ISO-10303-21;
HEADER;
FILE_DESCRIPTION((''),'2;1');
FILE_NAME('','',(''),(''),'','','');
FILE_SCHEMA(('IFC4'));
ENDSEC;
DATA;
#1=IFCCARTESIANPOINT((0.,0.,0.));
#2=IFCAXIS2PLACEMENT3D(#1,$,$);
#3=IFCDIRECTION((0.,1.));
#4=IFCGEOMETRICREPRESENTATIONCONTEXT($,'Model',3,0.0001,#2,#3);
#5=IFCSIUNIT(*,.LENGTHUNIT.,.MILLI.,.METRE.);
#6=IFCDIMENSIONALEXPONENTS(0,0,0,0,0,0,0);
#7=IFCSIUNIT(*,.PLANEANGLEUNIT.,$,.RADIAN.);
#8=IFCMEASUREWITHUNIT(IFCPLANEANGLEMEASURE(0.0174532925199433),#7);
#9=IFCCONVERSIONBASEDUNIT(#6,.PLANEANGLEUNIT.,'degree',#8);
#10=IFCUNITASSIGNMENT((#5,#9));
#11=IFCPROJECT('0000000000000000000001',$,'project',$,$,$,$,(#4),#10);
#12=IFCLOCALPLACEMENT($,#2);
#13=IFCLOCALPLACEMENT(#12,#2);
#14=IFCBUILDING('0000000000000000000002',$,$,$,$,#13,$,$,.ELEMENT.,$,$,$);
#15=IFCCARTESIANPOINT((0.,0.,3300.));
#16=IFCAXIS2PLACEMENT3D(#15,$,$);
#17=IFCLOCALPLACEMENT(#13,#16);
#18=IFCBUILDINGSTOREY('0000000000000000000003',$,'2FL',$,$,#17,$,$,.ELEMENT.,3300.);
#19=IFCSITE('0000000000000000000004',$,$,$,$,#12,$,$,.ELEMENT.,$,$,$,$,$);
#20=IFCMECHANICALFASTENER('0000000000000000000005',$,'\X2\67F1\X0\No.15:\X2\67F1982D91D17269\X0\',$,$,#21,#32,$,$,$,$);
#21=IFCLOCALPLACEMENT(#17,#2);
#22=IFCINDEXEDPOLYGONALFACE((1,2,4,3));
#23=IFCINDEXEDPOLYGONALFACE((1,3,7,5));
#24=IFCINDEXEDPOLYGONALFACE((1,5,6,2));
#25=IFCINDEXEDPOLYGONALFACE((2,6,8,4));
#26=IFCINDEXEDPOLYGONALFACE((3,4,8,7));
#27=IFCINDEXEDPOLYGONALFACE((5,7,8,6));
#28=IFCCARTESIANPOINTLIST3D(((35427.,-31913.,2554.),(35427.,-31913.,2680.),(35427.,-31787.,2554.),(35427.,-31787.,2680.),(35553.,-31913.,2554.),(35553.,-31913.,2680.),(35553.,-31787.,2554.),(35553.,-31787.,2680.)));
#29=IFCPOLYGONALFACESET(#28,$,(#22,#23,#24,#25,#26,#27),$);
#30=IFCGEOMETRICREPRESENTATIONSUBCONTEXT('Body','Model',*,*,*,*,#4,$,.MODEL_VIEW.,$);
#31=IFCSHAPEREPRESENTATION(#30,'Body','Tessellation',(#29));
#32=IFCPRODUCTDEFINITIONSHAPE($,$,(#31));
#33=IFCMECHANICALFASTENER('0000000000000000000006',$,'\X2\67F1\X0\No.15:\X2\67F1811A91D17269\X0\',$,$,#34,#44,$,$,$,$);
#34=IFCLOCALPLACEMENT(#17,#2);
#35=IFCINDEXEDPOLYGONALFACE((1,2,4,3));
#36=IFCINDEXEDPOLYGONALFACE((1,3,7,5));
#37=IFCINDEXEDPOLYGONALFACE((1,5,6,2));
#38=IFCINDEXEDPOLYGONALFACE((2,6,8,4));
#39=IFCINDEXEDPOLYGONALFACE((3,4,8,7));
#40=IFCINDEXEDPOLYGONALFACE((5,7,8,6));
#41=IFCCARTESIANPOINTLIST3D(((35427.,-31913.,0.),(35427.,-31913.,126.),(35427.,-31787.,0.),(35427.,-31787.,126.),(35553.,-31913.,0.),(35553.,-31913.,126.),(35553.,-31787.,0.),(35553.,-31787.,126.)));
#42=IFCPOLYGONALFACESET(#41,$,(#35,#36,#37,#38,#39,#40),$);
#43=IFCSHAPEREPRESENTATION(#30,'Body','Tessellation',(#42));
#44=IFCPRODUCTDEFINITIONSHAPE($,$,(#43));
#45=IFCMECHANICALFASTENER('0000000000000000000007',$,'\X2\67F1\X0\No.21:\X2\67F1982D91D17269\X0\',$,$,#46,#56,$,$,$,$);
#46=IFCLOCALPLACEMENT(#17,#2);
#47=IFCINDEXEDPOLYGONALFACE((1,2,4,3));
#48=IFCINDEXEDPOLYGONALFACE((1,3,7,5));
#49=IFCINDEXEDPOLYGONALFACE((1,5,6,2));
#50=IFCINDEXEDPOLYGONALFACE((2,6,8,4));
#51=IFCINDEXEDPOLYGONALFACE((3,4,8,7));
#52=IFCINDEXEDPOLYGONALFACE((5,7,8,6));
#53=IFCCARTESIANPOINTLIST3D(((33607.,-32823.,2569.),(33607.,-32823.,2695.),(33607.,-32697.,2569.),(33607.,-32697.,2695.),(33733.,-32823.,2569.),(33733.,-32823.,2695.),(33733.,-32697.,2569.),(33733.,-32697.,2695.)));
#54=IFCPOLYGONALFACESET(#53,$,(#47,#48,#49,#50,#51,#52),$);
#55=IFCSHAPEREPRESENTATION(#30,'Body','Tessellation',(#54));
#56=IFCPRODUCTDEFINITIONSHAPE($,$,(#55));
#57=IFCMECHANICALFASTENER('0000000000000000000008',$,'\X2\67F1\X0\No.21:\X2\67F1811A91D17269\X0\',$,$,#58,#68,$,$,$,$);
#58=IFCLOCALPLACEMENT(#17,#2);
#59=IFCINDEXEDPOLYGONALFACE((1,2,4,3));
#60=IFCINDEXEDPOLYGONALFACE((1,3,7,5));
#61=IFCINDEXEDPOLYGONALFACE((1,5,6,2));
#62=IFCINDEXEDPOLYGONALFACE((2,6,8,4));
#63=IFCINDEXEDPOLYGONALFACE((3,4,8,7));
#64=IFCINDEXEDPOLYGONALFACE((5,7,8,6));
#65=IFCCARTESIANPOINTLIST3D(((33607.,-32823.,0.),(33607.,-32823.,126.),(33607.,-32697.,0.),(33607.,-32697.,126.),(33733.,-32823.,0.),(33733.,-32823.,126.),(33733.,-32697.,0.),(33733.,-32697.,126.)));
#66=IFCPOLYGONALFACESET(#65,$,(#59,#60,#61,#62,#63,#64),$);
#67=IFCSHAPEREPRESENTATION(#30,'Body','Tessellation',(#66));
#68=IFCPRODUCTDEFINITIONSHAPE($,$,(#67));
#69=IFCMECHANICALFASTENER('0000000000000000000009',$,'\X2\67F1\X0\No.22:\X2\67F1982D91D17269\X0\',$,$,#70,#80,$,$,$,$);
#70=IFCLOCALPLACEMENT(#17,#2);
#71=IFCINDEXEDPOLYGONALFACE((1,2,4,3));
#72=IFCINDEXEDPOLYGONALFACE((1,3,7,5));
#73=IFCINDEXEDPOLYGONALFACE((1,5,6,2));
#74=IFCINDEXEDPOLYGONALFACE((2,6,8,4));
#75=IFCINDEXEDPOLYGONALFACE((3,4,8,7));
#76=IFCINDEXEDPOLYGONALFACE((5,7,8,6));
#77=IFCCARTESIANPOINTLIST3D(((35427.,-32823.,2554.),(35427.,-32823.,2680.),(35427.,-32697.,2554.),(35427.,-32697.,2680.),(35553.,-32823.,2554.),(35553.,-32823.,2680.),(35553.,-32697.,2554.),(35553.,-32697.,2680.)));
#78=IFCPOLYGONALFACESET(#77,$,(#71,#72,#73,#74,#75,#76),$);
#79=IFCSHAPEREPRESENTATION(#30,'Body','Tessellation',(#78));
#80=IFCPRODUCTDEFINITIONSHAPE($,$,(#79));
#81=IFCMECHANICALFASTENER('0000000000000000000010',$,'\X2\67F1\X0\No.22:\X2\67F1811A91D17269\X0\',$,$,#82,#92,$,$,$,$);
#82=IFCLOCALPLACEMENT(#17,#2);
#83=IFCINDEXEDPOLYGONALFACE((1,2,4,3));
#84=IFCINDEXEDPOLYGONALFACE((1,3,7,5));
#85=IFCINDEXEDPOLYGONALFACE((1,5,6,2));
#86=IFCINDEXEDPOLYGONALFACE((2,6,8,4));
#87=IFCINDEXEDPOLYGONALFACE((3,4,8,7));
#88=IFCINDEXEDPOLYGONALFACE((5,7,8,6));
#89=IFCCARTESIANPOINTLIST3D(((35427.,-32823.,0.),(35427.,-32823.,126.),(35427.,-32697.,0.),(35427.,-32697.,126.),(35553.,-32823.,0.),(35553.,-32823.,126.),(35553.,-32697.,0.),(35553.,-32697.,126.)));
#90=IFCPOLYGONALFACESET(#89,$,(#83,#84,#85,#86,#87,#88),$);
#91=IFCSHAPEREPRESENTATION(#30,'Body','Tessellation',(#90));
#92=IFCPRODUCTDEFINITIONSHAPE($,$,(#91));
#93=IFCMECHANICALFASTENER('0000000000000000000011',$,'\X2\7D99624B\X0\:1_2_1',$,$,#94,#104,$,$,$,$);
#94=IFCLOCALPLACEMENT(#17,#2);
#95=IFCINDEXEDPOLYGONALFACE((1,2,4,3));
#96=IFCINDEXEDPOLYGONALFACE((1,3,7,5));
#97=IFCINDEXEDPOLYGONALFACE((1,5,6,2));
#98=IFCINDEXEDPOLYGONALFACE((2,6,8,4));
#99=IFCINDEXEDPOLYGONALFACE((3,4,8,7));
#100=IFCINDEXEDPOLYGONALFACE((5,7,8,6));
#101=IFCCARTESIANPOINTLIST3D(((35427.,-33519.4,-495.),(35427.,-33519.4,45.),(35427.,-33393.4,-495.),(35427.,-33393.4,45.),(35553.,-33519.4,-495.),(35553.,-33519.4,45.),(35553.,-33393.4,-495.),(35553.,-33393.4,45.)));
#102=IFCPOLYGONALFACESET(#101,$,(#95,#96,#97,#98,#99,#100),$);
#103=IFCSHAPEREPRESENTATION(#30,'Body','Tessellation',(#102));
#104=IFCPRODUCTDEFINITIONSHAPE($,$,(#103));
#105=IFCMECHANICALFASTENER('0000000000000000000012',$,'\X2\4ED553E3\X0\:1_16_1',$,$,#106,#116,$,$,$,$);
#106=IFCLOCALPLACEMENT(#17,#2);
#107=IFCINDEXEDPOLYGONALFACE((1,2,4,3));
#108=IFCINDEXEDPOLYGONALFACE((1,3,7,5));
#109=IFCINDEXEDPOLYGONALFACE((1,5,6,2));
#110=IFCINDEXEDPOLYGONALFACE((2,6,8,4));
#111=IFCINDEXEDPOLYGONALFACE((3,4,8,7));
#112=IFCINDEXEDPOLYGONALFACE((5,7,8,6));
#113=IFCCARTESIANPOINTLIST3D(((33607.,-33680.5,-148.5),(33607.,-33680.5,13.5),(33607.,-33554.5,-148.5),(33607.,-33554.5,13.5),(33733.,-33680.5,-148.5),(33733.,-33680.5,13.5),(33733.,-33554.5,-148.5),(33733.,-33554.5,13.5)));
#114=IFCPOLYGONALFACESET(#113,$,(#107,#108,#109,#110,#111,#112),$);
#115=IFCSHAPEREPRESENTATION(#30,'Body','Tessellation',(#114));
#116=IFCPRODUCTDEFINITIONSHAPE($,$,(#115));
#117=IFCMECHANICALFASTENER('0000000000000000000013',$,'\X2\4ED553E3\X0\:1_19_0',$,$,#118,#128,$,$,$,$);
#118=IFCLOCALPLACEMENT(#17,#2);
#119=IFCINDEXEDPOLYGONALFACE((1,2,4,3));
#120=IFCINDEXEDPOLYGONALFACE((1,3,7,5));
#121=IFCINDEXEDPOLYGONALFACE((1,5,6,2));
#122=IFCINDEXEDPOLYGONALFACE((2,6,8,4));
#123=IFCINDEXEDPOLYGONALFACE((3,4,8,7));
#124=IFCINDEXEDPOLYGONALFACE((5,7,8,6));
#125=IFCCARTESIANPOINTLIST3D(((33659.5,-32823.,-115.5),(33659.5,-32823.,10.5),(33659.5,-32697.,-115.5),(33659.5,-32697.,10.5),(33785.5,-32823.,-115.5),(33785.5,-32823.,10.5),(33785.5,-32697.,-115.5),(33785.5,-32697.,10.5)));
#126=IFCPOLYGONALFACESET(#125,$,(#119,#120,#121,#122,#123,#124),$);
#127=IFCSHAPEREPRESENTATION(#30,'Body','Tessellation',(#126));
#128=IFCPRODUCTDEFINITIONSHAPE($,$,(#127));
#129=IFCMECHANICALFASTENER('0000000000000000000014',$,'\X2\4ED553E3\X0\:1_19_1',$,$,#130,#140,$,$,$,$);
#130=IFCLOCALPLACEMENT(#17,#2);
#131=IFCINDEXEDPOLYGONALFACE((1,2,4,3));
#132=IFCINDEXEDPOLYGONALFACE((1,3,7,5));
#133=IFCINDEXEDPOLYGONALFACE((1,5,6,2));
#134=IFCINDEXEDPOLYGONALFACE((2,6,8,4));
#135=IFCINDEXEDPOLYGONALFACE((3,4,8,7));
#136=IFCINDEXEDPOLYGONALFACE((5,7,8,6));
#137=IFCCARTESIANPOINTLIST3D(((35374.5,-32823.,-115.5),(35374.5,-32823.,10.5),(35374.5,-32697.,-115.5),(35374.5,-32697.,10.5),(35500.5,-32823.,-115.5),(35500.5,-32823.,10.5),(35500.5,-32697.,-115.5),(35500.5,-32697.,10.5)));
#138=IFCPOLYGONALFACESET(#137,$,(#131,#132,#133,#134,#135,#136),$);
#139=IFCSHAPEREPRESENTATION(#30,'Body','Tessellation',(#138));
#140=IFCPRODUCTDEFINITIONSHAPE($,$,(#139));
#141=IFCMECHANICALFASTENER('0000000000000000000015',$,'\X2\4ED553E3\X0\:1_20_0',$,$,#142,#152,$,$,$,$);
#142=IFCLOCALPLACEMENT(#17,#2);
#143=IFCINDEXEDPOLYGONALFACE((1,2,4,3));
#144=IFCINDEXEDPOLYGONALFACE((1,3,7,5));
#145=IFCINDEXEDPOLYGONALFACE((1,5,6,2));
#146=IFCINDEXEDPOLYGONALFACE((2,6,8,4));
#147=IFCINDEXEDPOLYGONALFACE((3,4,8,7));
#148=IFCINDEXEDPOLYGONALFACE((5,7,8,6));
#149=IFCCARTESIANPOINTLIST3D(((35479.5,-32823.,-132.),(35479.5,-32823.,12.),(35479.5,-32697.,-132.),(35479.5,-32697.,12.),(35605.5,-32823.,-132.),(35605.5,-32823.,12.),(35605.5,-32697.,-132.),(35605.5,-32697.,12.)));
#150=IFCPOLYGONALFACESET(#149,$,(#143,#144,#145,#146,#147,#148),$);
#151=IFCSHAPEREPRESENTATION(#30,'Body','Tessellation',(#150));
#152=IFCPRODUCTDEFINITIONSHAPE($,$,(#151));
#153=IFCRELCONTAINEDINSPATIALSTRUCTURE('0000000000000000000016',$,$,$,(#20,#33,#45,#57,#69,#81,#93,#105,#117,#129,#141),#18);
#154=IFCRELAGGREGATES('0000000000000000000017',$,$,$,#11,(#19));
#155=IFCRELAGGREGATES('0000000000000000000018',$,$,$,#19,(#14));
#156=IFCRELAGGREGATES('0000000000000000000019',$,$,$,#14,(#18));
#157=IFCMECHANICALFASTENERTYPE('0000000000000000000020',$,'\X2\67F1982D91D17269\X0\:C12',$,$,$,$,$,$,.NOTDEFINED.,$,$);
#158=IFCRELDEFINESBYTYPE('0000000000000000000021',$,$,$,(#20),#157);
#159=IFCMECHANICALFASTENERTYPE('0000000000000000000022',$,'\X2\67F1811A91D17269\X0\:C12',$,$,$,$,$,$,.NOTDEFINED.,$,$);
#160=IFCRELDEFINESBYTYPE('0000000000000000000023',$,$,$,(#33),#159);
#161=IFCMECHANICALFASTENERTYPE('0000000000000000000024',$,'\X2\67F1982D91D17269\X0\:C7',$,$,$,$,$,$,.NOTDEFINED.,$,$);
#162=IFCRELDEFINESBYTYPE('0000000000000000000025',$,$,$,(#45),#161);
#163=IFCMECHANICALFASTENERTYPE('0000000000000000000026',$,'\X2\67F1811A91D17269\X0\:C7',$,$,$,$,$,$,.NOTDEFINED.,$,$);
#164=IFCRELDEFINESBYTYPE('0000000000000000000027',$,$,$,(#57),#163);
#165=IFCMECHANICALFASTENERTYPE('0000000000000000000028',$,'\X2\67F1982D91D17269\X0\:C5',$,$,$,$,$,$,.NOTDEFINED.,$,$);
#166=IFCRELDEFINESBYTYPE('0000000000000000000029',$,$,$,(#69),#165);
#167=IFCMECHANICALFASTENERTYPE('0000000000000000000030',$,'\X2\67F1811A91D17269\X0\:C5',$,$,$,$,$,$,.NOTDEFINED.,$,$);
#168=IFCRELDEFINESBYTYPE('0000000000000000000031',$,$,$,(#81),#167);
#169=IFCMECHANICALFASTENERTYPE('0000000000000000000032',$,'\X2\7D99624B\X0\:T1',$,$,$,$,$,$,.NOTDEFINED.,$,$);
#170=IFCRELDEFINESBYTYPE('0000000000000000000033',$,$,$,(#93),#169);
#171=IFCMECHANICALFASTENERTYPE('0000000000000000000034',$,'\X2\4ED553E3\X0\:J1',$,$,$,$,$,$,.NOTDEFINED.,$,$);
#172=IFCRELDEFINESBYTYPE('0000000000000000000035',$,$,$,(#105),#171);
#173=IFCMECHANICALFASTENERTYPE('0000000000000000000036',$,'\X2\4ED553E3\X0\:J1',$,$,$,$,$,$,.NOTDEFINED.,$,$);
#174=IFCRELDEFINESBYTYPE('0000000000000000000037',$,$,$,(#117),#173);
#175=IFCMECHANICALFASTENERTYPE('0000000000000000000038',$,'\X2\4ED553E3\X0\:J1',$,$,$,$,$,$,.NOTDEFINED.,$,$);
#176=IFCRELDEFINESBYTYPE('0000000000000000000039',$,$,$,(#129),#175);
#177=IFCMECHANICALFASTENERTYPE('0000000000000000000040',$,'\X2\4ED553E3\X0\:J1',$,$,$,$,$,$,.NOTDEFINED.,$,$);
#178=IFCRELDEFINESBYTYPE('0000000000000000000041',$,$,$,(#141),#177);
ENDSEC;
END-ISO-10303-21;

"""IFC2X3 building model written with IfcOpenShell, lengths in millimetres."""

from ifc_helpers import new_model, entity, si_unit, converted_unit, direction, frame, origin, origin_with_axes, origin_2d, place, context, subcontext, project, spatial, rectangle, extrude, type_object, element, save


model = new_model("IFC2X3")

# Units and contexts
model_context = context("Model", 3, precision=0.0001, world=origin(), true_north=direction((0.0, 1.0)))
body_context = subcontext(model_context, "Body", "Model", "MODEL_VIEW")
ifc_project = project(units=[si_unit("LENGTHUNIT", "METRE", prefix="MILLI"), converted_unit("PLANEANGLEUNIT", "degree", entity("IfcPlaneAngleMeasure", 0.0174532925199433), si_unit("PLANEANGLEUNIT", "RADIAN"), dimensions=[0, 0, 0, 0, 0, 0, 0])], contexts=[model_context])

# Site, building, storey
site_placement = place(None, origin())
site = spatial("IfcSite", under=ifc_project, at=site_placement, CompositionType="ELEMENT")
building_placement = place(site_placement, origin())
building = spatial("IfcBuilding", under=site, at=building_placement, CompositionType="ELEMENT")
storey_placement = place(building_placement, frame((0.0, 0.0, 3300.0)))
storey = spatial("IfcBuildingStorey", under=building, at=storey_placement, Name="2FL", CompositionType="ELEMENT", Elevation=3300.0)

# Mechanical fasteners
mechanical_fastener_type_1 = type_object("IfcMechanicalFastenerType", Name="柱頭金物:C12")
mechanical_fastener_1_placement = place(storey_placement, frame((35490.0, -31850.0, 2554.0)))
element("IfcMechanicalFastener", 1, at=mechanical_fastener_1_placement, inside=storey, type_object=mechanical_fastener_type_1, Name="柱No.15:柱頭金物", context=body_context, shape_type="SweptSolid", body=[
    extrude(rectangle(XDim=126.0, YDim=126.0, at=origin_2d()), origin_with_axes(), (0.0, 0.0, 1.0), 126.0),
])
mechanical_fastener_type_2 = type_object("IfcMechanicalFastenerType", Name="柱脚金物:C12")
mechanical_fastener_2_placement = place(storey_placement, frame((35490.0, -31850.0, 0.0)))
element("IfcMechanicalFastener", 2, at=mechanical_fastener_2_placement, inside=storey, type_object=mechanical_fastener_type_2, Name="柱No.15:柱脚金物", context=body_context, shape_type="SweptSolid", body=[
    extrude(rectangle(XDim=126.0, YDim=126.0, at=origin_2d()), origin_with_axes(), (0.0, 0.0, 1.0), 126.0),
])
mechanical_fastener_type_3 = type_object("IfcMechanicalFastenerType", Name="柱頭金物:C7")
mechanical_fastener_3_placement = place(storey_placement, frame((33670.0, -32760.0, 2569.0)))
element("IfcMechanicalFastener", 3, at=mechanical_fastener_3_placement, inside=storey, type_object=mechanical_fastener_type_3, Name="柱No.21:柱頭金物", context=body_context, shape_type="SweptSolid", body=[
    extrude(rectangle(XDim=126.0, YDim=126.0, at=origin_2d()), origin_with_axes(), (0.0, 0.0, 1.0), 126.0),
])
mechanical_fastener_type_4 = type_object("IfcMechanicalFastenerType", Name="柱脚金物:C7")
mechanical_fastener_4_placement = place(storey_placement, frame((33670.0, -32760.0, 0.0)))
element("IfcMechanicalFastener", 4, at=mechanical_fastener_4_placement, inside=storey, type_object=mechanical_fastener_type_4, Name="柱No.21:柱脚金物", context=body_context, shape_type="SweptSolid", body=[
    extrude(rectangle(XDim=126.0, YDim=126.0, at=origin_2d()), origin_with_axes(), (0.0, 0.0, 1.0), 126.0),
])
mechanical_fastener_type_5 = type_object("IfcMechanicalFastenerType", Name="柱頭金物:C5")
mechanical_fastener_5_placement = place(storey_placement, frame((35490.0, -32760.0, 2554.0)))
element("IfcMechanicalFastener", 5, at=mechanical_fastener_5_placement, inside=storey, type_object=mechanical_fastener_type_5, Name="柱No.22:柱頭金物", context=body_context, shape_type="SweptSolid", body=[
    extrude(rectangle(XDim=126.0, YDim=126.0, at=origin_2d()), origin_with_axes(), (0.0, 0.0, 1.0), 126.0),
])
mechanical_fastener_type_6 = type_object("IfcMechanicalFastenerType", Name="柱脚金物:C5")
mechanical_fastener_6_placement = place(storey_placement, frame((35490.0, -32760.0, 0.0)))
element("IfcMechanicalFastener", 6, at=mechanical_fastener_6_placement, inside=storey, type_object=mechanical_fastener_type_6, Name="柱No.22:柱脚金物", context=body_context, shape_type="SweptSolid", body=[
    extrude(rectangle(XDim=126.0, YDim=126.0, at=origin_2d()), origin_with_axes(), (0.0, 0.0, 1.0), 126.0),
])
mechanical_fastener_type_7 = type_object("IfcMechanicalFastenerType", Name="継手:T1")
mechanical_fastener_7_placement = place(storey_placement, frame((35490.0, -33456.3, -495.0)))
element("IfcMechanicalFastener", 7, at=mechanical_fastener_7_placement, inside=storey, type_object=mechanical_fastener_type_7, Name="継手:1_2_1", context=body_context, shape_type="SweptSolid", body=[
    extrude(rectangle(XDim=126.0, YDim=126.0, at=origin_2d()), origin_with_axes(), (0.0, 0.0, 1.0), 540.0),
])
mechanical_fastener_type_8 = type_object("IfcMechanicalFastenerType", Name="仕口:J1")
mechanical_fastener_8_placement = place(storey_placement, frame((33670.0, -33617.5, -148.5)))
element("IfcMechanicalFastener", 8, at=mechanical_fastener_8_placement, inside=storey, type_object=mechanical_fastener_type_8, Name="仕口:1_16_1", context=body_context, shape_type="SweptSolid", body=[
    extrude(rectangle(XDim=126.0, YDim=126.0, at=origin_2d()), origin_with_axes(), (0.0, 0.0, 1.0), 162.0),
])
mechanical_fastener_type_9 = type_object("IfcMechanicalFastenerType", Name="仕口:J1")
mechanical_fastener_9_placement = place(storey_placement, frame((33722.5, -32760.0, -115.5)))
element("IfcMechanicalFastener", 9, at=mechanical_fastener_9_placement, inside=storey, type_object=mechanical_fastener_type_9, Name="仕口:1_19_0", context=body_context, shape_type="SweptSolid", body=[
    extrude(rectangle(XDim=126.0, YDim=126.0, at=origin_2d()), origin_with_axes(), (0.0, 0.0, 1.0), 126.0),
])
mechanical_fastener_type_10 = type_object("IfcMechanicalFastenerType", Name="仕口:J1")
mechanical_fastener_10_placement = place(storey_placement, frame((35437.5, -32760.0, -115.5)))
element("IfcMechanicalFastener", 10, at=mechanical_fastener_10_placement, inside=storey, type_object=mechanical_fastener_type_10, Name="仕口:1_19_1", context=body_context, shape_type="SweptSolid", body=[
    extrude(rectangle(XDim=126.0, YDim=126.0, at=origin_2d()), origin_with_axes(), (0.0, 0.0, 1.0), 126.0),
])
mechanical_fastener_type_11 = type_object("IfcMechanicalFastenerType", Name="仕口:J1")
mechanical_fastener_11_placement = place(storey_placement, frame((35542.5, -32760.0, -132.0)))
element("IfcMechanicalFastener", 11, at=mechanical_fastener_11_placement, inside=storey, type_object=mechanical_fastener_type_11, Name="仕口:1_20_0", context=body_context, shape_type="SweptSolid", body=[
    extrude(rectangle(XDim=126.0, YDim=126.0, at=origin_2d()), origin_with_axes(), (0.0, 0.0, 1.0), 144.0),
])

save(model, "model.ifc")
